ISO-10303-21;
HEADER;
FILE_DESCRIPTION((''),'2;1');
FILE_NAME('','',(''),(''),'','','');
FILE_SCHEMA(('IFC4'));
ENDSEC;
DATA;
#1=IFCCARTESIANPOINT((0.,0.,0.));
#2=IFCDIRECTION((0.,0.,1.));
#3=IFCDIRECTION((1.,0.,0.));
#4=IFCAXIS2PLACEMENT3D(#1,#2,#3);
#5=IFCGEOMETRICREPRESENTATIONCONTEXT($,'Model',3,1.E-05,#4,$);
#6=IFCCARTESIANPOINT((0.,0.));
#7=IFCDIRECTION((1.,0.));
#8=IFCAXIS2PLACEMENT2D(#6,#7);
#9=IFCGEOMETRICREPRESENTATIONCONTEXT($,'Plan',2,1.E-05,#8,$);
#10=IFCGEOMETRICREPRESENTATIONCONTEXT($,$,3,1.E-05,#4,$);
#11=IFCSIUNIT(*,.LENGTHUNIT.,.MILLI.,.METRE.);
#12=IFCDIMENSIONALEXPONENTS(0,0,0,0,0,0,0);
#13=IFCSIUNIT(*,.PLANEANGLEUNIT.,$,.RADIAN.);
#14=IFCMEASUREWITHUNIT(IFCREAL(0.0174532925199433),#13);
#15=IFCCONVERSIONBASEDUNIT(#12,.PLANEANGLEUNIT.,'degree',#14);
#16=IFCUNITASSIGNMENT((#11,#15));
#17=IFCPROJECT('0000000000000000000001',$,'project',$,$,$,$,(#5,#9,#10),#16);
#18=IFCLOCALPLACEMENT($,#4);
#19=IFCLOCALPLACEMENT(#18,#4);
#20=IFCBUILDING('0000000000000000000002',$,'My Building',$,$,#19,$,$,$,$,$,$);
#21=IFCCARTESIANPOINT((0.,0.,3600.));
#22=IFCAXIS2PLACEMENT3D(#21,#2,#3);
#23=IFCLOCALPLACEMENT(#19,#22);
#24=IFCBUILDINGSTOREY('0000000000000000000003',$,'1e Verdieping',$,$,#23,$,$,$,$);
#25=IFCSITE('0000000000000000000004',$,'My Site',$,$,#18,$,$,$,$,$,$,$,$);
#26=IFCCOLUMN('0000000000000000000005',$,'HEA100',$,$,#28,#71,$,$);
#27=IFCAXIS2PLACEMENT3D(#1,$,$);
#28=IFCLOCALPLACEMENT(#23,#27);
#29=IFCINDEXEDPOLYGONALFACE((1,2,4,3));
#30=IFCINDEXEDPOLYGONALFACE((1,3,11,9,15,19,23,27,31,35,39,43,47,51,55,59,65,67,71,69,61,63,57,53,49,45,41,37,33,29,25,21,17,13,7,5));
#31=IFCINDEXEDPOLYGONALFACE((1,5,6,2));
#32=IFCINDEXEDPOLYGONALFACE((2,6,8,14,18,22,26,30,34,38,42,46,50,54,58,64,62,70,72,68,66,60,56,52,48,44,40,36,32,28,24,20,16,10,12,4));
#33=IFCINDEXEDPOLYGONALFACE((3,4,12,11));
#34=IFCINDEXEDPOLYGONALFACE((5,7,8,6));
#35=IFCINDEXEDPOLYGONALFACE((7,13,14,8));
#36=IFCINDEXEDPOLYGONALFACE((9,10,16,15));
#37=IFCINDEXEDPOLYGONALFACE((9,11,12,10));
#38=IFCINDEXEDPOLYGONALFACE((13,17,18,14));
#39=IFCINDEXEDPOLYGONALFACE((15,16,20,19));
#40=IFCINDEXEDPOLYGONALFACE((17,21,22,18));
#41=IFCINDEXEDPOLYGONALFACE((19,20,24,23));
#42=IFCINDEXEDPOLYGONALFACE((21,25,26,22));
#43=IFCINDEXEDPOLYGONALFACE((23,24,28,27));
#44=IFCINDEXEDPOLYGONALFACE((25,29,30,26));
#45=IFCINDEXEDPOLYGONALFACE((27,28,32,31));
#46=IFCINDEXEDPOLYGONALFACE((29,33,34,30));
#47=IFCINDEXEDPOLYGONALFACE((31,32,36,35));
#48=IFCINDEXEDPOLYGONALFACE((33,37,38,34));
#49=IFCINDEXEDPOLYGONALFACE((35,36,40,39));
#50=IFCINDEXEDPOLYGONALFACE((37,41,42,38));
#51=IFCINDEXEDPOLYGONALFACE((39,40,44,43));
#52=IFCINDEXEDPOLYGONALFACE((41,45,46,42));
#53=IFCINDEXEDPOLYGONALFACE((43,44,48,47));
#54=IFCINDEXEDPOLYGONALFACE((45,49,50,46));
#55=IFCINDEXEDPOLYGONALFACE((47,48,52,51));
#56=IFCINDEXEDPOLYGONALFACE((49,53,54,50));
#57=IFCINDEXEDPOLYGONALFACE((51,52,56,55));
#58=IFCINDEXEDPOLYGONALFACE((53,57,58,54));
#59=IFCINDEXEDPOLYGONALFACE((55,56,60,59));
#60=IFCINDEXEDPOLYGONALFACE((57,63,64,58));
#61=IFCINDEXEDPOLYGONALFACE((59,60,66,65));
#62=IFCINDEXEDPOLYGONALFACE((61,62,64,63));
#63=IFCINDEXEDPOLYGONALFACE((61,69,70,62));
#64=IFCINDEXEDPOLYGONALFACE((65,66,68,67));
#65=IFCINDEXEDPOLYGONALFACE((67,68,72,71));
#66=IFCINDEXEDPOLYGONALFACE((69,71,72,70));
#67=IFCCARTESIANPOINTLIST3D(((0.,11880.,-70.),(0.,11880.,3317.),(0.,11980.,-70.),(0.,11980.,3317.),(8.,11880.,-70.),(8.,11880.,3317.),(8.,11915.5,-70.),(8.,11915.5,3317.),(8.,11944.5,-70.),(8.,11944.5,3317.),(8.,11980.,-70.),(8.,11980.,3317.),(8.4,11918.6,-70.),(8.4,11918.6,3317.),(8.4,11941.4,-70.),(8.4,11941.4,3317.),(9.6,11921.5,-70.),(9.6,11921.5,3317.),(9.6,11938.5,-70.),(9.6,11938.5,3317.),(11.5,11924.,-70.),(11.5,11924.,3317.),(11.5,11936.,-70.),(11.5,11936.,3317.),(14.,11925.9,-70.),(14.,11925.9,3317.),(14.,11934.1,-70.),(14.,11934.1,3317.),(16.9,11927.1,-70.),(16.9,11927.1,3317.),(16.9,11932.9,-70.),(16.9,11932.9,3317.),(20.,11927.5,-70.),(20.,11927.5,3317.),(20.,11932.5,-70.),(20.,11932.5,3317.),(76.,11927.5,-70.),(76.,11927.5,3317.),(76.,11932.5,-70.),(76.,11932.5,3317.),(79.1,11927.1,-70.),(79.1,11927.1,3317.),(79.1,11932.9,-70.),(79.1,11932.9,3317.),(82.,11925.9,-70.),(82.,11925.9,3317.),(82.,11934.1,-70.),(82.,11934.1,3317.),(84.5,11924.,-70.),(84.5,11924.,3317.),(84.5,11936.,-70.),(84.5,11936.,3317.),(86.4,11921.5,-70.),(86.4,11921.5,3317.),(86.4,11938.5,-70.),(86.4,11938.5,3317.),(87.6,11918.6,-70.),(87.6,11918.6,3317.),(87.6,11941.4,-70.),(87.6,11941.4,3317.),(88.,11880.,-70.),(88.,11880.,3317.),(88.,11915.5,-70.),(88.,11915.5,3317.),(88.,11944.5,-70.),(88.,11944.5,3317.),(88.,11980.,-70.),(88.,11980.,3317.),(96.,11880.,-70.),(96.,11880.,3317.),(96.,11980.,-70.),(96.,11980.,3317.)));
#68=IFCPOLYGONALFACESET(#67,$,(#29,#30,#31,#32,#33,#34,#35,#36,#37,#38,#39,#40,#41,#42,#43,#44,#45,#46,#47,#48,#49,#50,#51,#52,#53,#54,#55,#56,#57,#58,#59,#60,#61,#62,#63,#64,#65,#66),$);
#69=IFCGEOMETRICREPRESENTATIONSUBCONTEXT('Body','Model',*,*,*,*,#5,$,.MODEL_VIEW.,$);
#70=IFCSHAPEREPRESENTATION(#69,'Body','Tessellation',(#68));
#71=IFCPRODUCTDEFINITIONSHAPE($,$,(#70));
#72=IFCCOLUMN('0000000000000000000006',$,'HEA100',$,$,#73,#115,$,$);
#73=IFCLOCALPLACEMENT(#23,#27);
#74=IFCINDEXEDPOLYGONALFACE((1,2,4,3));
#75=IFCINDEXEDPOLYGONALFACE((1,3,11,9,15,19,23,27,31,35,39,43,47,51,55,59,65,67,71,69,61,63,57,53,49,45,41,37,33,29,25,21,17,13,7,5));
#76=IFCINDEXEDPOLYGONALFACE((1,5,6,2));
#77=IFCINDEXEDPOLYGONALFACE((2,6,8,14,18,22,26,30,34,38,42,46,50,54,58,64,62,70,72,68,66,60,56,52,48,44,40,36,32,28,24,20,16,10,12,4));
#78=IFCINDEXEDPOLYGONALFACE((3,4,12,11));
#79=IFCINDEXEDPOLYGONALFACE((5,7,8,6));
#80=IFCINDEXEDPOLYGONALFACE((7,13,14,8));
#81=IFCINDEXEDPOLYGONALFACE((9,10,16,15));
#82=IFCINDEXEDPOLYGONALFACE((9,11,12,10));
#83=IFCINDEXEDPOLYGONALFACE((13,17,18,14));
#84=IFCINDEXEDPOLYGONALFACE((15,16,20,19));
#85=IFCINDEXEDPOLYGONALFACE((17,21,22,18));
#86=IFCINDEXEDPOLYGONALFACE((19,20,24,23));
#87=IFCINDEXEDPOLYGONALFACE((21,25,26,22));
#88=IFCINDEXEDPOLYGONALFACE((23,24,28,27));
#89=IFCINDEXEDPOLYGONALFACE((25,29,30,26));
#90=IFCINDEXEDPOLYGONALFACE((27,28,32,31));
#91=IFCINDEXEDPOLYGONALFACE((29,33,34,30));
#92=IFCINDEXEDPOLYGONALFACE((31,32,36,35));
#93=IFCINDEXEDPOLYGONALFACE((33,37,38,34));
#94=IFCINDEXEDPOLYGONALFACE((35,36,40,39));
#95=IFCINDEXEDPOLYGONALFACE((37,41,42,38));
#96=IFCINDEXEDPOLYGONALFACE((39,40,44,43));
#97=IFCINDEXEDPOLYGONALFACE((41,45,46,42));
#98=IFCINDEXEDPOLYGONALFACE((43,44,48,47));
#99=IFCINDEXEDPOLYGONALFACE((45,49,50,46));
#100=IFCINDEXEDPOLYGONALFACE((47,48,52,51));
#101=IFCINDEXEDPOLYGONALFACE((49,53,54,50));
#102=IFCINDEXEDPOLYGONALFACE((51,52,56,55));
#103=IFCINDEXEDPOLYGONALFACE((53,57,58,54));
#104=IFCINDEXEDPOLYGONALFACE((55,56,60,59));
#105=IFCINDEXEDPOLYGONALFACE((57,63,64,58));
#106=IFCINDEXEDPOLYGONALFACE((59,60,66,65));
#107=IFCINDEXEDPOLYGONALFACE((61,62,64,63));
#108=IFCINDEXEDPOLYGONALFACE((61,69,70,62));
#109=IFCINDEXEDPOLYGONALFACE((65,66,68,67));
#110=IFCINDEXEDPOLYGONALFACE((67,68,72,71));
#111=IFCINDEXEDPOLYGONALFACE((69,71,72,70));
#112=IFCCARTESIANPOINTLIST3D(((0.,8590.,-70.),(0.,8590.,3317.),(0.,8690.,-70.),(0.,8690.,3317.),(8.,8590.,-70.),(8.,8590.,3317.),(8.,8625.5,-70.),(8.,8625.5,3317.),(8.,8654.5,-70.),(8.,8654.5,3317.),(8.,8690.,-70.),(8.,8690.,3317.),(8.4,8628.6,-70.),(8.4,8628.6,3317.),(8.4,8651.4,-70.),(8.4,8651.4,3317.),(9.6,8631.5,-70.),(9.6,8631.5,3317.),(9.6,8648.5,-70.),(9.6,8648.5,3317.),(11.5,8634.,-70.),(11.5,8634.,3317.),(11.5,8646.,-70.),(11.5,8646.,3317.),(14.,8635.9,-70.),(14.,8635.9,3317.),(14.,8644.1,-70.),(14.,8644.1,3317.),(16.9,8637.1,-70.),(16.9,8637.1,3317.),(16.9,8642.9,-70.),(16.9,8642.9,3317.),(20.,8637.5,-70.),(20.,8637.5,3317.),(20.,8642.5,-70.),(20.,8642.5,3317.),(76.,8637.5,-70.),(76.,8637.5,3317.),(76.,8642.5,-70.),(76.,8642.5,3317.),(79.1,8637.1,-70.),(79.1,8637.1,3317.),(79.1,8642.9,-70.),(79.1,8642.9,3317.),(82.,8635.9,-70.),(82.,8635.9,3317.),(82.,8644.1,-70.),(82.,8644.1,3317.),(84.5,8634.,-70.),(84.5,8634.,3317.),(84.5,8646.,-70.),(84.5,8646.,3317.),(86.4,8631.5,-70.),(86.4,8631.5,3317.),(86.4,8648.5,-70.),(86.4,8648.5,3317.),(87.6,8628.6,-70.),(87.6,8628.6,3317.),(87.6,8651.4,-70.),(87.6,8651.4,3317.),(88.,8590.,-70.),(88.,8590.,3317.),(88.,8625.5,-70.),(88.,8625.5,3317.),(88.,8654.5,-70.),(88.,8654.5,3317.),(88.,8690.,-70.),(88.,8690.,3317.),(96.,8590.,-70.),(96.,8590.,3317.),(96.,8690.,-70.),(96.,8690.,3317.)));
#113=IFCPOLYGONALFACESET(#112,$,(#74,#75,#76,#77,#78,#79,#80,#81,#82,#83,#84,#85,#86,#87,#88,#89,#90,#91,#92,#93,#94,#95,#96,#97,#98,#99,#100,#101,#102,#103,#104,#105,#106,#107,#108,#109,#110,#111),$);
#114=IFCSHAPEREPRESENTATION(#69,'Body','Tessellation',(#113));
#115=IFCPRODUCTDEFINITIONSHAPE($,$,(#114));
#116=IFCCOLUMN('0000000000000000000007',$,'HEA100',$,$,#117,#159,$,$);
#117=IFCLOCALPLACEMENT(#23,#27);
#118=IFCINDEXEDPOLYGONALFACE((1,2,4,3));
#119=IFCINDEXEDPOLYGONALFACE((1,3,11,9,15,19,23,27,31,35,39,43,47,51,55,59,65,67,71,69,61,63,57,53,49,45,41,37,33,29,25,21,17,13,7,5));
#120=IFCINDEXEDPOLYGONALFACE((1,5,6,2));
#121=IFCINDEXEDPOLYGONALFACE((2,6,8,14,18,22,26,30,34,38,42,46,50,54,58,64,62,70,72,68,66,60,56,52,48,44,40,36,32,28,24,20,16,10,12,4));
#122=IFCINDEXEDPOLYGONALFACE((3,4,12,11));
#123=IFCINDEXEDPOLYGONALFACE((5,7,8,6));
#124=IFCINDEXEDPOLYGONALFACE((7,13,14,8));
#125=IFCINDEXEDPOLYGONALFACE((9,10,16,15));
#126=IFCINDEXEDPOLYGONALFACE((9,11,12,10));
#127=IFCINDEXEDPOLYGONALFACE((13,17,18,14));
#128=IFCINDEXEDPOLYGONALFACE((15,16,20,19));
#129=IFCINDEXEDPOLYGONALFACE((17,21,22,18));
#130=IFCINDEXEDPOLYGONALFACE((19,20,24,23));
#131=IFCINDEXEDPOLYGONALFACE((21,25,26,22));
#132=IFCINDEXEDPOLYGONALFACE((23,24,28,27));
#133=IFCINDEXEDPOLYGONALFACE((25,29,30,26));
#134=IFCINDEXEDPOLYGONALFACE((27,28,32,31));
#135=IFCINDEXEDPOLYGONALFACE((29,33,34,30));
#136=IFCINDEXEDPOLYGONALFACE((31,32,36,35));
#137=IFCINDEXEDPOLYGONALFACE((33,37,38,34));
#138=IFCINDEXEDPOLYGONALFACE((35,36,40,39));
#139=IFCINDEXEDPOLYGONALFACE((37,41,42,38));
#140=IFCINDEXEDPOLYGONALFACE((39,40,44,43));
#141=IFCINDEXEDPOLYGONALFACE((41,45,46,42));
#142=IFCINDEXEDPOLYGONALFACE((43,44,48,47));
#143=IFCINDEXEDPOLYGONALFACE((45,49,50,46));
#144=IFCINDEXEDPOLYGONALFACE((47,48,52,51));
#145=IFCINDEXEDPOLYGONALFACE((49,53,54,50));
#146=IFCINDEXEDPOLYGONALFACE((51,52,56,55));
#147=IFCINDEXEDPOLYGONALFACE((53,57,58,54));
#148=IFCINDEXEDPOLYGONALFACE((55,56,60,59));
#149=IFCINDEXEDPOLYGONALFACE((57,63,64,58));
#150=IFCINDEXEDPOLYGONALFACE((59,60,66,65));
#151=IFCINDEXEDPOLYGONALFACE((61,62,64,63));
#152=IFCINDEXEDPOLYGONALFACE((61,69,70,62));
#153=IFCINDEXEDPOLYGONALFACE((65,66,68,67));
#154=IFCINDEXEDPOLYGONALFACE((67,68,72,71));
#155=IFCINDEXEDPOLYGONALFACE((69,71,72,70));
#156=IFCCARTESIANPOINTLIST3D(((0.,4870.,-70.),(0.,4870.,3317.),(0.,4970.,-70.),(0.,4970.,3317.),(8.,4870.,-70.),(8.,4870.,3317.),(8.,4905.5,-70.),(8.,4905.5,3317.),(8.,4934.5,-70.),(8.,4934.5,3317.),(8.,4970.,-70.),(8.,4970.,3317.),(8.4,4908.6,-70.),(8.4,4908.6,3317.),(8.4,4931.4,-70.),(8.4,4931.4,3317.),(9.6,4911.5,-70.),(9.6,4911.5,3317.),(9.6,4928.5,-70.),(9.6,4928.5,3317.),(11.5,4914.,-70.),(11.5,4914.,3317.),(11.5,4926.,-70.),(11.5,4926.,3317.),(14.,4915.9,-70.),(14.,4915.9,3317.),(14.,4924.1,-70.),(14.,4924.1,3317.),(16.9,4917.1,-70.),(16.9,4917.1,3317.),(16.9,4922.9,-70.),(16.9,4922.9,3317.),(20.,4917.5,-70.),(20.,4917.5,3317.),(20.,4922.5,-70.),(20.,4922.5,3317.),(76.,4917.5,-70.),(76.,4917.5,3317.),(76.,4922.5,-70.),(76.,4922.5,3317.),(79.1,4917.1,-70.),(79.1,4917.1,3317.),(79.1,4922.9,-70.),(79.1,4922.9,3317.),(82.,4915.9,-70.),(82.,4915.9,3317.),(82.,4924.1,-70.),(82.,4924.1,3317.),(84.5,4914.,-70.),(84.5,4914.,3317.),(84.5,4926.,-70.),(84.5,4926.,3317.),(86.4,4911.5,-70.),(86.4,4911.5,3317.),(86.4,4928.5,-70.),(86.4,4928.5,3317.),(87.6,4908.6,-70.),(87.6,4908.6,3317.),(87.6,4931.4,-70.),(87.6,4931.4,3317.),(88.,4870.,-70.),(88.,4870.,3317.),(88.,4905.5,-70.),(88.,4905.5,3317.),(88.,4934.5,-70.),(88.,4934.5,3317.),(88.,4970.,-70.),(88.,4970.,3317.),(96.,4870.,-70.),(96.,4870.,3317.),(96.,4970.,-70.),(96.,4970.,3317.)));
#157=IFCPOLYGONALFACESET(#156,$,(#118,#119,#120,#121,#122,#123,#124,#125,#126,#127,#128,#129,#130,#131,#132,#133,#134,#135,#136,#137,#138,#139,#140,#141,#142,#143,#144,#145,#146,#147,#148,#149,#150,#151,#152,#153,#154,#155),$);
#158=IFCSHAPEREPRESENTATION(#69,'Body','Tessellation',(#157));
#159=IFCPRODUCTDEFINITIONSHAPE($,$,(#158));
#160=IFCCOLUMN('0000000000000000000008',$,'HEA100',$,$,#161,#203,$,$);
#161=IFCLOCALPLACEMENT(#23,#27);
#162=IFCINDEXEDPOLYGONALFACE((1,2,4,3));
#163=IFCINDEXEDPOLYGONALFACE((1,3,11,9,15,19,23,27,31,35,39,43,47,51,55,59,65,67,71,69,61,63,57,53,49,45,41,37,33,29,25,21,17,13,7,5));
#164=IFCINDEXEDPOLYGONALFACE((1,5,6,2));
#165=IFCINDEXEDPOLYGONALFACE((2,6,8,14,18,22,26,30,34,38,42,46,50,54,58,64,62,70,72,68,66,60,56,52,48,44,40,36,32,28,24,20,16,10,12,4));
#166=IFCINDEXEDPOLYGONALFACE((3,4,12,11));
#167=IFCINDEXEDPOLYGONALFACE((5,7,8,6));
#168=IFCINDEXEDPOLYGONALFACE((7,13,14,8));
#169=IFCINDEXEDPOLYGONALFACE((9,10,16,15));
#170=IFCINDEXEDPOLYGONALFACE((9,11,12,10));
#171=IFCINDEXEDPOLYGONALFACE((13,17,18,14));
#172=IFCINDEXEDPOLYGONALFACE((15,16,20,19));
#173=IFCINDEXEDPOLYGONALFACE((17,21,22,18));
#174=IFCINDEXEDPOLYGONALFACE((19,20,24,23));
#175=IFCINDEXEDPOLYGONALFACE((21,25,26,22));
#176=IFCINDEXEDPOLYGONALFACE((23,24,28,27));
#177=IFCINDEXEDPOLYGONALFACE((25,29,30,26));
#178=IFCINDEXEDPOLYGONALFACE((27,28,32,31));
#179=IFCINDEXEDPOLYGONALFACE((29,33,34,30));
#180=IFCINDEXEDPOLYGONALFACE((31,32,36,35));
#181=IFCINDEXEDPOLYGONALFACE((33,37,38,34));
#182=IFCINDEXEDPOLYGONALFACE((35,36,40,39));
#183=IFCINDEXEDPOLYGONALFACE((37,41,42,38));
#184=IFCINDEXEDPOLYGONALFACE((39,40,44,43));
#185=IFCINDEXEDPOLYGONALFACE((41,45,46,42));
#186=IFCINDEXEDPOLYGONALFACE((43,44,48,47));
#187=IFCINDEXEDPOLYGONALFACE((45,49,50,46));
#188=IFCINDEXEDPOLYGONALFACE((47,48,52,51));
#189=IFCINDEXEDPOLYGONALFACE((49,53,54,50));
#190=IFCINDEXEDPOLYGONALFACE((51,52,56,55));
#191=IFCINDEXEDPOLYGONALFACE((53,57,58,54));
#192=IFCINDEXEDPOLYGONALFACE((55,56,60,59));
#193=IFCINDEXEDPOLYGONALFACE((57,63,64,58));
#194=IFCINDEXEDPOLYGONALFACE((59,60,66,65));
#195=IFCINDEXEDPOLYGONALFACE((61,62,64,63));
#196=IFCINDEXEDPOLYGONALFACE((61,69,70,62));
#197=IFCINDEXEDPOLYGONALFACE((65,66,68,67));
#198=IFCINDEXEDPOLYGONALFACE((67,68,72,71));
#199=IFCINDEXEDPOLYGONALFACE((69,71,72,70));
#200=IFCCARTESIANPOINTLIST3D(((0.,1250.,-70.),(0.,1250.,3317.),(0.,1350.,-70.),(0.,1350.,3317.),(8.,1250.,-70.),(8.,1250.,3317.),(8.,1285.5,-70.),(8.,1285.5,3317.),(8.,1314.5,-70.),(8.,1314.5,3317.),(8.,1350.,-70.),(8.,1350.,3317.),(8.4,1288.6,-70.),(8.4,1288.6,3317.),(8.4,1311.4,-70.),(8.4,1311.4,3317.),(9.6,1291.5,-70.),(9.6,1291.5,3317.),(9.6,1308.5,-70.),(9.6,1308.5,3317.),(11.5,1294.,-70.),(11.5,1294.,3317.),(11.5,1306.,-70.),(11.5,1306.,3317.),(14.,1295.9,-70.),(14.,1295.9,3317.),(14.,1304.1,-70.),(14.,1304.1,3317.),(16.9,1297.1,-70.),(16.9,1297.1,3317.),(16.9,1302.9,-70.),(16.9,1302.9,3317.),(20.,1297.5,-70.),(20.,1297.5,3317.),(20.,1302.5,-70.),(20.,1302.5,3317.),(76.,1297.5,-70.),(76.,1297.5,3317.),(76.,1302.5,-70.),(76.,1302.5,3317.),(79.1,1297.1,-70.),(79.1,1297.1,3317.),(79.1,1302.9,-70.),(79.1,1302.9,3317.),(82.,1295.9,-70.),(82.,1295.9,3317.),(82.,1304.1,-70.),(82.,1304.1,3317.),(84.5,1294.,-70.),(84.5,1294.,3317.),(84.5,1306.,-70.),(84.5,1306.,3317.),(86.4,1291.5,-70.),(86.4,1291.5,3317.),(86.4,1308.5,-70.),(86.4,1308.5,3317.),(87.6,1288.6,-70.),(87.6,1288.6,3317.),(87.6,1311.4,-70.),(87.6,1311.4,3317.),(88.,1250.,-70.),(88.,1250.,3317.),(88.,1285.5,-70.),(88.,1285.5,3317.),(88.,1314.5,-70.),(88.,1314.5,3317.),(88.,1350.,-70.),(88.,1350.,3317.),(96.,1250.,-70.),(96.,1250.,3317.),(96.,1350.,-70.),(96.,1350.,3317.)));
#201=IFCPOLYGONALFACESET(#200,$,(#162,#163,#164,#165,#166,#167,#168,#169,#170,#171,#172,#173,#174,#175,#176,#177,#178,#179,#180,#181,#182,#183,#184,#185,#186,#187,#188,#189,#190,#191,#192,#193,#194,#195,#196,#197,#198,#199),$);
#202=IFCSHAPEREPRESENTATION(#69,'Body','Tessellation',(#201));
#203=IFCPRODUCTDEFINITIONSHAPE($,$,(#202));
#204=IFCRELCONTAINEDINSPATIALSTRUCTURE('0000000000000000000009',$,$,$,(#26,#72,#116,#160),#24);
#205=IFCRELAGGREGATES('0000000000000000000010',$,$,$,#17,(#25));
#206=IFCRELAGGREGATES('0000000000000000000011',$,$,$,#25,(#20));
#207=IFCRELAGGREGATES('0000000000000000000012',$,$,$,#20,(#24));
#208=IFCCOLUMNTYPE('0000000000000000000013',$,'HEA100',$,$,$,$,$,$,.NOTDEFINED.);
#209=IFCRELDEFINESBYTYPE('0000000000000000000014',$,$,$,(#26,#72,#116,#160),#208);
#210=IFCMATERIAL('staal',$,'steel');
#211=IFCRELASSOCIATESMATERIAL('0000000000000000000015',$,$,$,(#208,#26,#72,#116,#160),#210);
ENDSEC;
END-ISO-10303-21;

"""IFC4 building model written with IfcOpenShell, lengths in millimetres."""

from ifc_helpers import new_model, entity, si_unit, converted_unit, frame, origin_with_axes, origin_2d_with_axis, place, context, subcontext, project, spatial, i_section, extrude, material, material_profile, profile_set, profile_usage, type_object, element, save


model = new_model("IFC4")

# Units and contexts
model_context = context("Model", 3, precision=1e-05, world=origin_with_axes())
plan_context = context("Plan", 2, precision=1e-05, world=origin_2d_with_axis())
context_of_model = context(None, 3, precision=1e-05, world=origin_with_axes())
body_context = subcontext(model_context, "Body", "Model", "MODEL_VIEW")
ifc_project = project(units=[si_unit("LENGTHUNIT", "METRE", prefix="MILLI"), converted_unit("PLANEANGLEUNIT", "degree", entity("IfcReal", 0.0174532925199433), si_unit("PLANEANGLEUNIT", "RADIAN"), dimensions=[0, 0, 0, 0, 0, 0, 0])], contexts=[model_context, plan_context, context_of_model])

# Site, building, storey
site_placement = place(None, origin_with_axes())
site = spatial("IfcSite", under=ifc_project, at=site_placement, Name="My Site")
building_placement = place(site_placement, origin_with_axes())
building = spatial("IfcBuilding", under=site, at=building_placement, Name="My Building")
storey_placement = place(building_placement, frame((0.0, 0.0, 3600.0), z_axis=(0.0, 0.0, 1.0), x_axis=(1.0, 0.0, 0.0)))
storey = spatial("IfcBuildingStorey", under=building, at=storey_placement, Name="1e Verdieping")

# Columns
ifc_material_1 = material(Name="staal", Category="steel")
ifc_material_profile_1 = material_profile(ifc_material_1, i_section(OverallWidth=100.0, OverallDepth=96.0, WebThickness=5.0, FlangeThickness=8.0, FilletRadius=12.0))
ifc_profile_set_1 = profile_set([ifc_material_profile_1], Name="HEA100")
column_type_1 = type_object("IfcColumnType", Name="HEA100", PredefinedType="NOTDEFINED", material=ifc_profile_set_1)
ifc_profile_usage_1 = profile_usage(ifc_profile_set_1)
column_1_placement = place(storey_placement, frame((48.0, 11930.0, -70.0), z_axis=(0.0, 0.0, 1.0), x_axis=(0.0, 1.0, 0.0)))
element("IfcColumn", 1, at=column_1_placement, inside=storey, type_object=column_type_1, material=ifc_profile_usage_1, Name="HEA100", context=body_context, shape_type="SweptSolid", body=[
    extrude(i_section(OverallWidth=100.0, OverallDepth=96.0, WebThickness=5.0, FlangeThickness=8.0, FilletRadius=12.0), origin_with_axes(), (0.0, 0.0, 1.0), 3387.0),
])
ifc_profile_usage_2 = profile_usage(ifc_profile_set_1)
column_2_placement = place(storey_placement, frame((48.0, 8640.0, -70.0), z_axis=(0.0, 0.0, 1.0), x_axis=(0.0, 1.0, 0.0)))
element("IfcColumn", 2, at=column_2_placement, inside=storey, type_object=column_type_1, material=ifc_profile_usage_2, Name="HEA100", context=body_context, shape_type="SweptSolid", body=[
    extrude(i_section(OverallWidth=100.0, OverallDepth=96.0, WebThickness=5.0, FlangeThickness=8.0, FilletRadius=12.0), origin_with_axes(), (0.0, 0.0, 1.0), 3387.0),
])
ifc_profile_usage_3 = profile_usage(ifc_profile_set_1)
column_3_placement = place(storey_placement, frame((48.0, 4920.0, -70.0), z_axis=(0.0, 0.0, 1.0), x_axis=(0.0, 1.0, 0.0)))
element("IfcColumn", 3, at=column_3_placement, inside=storey, type_object=column_type_1, material=ifc_profile_usage_3, Name="HEA100", context=body_context, shape_type="SweptSolid", body=[
    extrude(i_section(OverallWidth=100.0, OverallDepth=96.0, WebThickness=5.0, FlangeThickness=8.0, FilletRadius=12.0), origin_with_axes(), (0.0, 0.0, 1.0), 3387.0),
])
ifc_profile_usage_4 = profile_usage(ifc_profile_set_1)
column_4_placement = place(storey_placement, frame((48.0, 1300.0, -70.0), z_axis=(0.0, 0.0, 1.0), x_axis=(0.0, 1.0, 0.0)))
element("IfcColumn", 4, at=column_4_placement, inside=storey, type_object=column_type_1, material=ifc_profile_usage_4, Name="HEA100", context=body_context, shape_type="SweptSolid", body=[
    extrude(i_section(OverallWidth=100.0, OverallDepth=96.0, WebThickness=5.0, FlangeThickness=8.0, FilletRadius=12.0), origin_with_axes(), (0.0, 0.0, 1.0), 3387.0),
])

save(model, "model.ifc")
